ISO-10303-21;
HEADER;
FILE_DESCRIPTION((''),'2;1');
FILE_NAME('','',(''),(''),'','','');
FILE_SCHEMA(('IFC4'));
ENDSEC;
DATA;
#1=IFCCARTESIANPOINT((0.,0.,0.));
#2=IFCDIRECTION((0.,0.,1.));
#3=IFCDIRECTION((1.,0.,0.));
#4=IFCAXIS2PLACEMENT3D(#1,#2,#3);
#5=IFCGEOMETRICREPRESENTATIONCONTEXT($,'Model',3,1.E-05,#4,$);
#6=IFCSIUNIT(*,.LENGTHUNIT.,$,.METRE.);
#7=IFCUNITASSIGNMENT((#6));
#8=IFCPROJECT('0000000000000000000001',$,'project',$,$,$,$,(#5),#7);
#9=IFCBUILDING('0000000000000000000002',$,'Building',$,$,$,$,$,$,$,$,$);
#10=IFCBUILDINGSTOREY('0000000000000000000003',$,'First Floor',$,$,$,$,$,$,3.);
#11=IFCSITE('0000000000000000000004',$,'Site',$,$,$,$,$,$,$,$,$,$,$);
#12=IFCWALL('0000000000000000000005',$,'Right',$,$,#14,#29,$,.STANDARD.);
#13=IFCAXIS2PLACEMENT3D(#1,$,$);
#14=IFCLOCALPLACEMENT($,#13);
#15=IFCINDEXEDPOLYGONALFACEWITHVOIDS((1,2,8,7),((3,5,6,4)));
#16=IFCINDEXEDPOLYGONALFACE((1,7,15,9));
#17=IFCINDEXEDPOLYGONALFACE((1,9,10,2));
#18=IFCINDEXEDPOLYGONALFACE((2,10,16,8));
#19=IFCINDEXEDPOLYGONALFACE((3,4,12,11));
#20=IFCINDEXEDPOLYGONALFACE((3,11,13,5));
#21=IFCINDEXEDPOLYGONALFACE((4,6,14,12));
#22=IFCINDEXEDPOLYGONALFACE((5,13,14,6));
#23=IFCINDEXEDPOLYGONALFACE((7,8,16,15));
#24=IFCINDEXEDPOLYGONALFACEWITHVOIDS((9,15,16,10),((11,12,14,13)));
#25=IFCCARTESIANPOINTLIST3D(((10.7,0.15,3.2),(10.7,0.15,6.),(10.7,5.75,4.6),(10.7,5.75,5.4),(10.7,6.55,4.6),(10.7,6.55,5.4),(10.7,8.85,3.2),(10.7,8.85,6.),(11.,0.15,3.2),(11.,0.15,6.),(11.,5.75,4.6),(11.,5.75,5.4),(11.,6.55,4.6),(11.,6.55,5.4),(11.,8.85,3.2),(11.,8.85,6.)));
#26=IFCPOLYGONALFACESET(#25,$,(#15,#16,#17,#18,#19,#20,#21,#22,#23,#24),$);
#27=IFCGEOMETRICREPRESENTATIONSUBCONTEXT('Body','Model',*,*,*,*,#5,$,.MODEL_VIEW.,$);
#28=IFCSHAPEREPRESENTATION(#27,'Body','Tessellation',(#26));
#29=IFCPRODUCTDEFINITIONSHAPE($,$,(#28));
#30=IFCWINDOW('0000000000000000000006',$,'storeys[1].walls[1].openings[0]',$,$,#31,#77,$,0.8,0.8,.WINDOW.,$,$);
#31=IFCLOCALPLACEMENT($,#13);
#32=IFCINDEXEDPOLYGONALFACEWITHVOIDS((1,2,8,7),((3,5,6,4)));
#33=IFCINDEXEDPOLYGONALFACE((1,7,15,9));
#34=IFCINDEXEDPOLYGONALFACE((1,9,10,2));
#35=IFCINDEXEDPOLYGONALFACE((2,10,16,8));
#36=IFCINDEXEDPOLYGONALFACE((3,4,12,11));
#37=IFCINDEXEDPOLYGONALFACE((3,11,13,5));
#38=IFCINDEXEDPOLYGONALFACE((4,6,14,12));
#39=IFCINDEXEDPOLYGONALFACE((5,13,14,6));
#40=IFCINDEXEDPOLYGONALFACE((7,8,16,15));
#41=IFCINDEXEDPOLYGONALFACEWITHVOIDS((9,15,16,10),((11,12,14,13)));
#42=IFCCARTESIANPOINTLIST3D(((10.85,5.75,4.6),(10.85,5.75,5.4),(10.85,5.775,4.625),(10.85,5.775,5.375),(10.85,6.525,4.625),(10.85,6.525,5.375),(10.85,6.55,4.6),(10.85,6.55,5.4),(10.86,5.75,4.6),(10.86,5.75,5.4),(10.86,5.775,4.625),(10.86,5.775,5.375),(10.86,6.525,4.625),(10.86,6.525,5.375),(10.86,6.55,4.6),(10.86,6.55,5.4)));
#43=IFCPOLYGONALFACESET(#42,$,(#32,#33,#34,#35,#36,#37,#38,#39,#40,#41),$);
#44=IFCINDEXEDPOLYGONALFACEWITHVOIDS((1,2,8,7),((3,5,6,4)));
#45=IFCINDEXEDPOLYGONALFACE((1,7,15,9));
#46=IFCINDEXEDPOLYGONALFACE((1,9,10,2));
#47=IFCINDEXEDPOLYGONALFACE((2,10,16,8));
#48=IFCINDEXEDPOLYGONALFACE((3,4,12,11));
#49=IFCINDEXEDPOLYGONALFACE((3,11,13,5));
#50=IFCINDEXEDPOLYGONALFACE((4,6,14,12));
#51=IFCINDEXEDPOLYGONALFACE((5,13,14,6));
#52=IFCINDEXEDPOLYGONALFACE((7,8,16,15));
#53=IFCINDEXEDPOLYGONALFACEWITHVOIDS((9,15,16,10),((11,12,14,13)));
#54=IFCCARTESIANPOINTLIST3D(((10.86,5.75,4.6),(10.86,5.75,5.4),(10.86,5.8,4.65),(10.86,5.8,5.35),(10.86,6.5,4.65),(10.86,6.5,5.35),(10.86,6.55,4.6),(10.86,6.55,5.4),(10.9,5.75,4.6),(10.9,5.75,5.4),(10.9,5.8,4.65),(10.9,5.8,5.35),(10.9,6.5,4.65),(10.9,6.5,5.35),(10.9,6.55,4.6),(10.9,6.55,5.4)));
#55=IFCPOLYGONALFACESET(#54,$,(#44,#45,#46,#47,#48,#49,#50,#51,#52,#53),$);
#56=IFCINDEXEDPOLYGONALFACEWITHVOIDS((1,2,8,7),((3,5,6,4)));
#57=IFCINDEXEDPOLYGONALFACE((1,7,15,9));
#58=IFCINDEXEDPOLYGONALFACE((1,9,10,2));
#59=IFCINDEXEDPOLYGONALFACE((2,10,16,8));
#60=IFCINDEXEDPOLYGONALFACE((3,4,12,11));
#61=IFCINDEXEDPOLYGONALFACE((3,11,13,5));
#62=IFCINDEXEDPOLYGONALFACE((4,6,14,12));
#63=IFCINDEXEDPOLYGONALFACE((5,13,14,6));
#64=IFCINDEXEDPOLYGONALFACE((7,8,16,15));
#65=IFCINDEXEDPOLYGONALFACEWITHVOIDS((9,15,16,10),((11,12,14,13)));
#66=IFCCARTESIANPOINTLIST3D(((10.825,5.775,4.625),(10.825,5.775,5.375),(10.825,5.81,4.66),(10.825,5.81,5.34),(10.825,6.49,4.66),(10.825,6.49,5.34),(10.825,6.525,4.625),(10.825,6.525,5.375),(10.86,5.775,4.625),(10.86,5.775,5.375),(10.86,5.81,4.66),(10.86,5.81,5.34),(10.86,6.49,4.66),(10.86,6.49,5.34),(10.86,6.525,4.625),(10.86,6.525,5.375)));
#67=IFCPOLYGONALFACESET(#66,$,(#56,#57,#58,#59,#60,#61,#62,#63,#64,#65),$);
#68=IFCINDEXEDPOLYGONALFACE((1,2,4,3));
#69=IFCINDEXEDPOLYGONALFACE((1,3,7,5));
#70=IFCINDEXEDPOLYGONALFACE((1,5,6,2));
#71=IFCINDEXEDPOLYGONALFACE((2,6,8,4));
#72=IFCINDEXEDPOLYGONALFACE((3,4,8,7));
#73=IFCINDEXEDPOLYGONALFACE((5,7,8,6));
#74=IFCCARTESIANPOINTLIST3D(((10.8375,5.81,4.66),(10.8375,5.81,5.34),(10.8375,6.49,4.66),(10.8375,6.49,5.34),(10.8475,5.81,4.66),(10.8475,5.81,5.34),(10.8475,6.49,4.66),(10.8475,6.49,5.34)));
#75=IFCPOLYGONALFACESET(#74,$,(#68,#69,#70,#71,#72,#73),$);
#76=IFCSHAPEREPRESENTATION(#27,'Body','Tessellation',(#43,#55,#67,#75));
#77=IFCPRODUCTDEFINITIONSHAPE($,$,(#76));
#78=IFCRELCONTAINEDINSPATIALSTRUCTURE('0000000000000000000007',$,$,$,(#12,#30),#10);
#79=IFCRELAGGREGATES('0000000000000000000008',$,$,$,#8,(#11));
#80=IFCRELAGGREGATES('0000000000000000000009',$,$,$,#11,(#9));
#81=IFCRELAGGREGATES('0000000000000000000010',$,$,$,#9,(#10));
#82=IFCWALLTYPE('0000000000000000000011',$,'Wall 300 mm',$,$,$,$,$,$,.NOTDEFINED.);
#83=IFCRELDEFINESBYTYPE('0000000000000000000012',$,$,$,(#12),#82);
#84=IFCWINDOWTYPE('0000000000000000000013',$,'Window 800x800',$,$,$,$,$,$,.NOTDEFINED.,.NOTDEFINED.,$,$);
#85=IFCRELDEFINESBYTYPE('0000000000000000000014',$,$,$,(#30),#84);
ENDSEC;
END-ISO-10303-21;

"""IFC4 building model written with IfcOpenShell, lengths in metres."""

from ifc_helpers import new_model, si_unit, frame, origin_with_axes, place, context, subcontext, project, spatial, line, indexed_curve, outline, extrude, type_object, element, fill, save


model = new_model("IFC4")

# Units and contexts
model_context = context("Model", 3, precision=1e-05, world=origin_with_axes())
body_context = subcontext(model_context, "Body", "Model", "MODEL_VIEW")
ifc_project = project(units=[si_unit("LENGTHUNIT", "METRE")], contexts=[model_context])

# Site, building, storey
site = spatial("IfcSite", under=ifc_project, Name="Site")
building = spatial("IfcBuilding", under=site, Name="Building")
storey = spatial("IfcBuildingStorey", under=building, Name="First Floor", Elevation=3.0)

# Shared definitions
wall_type_1 = type_object("IfcWallType", Name="Wall 300 mm", PredefinedType="NOTDEFINED")

# Wall, opening, window
wall_1_placement = place(None, frame((10.85, 0.15, 3.2), z_axis=(0.0, 0.0, 1.0), x_axis=(0.0, 1.0, 0.0)))
wall_1 = element("IfcWall", 1, at=wall_1_placement, inside=storey, type_object=wall_type_1, Name="Right", PredefinedType="STANDARD", context=body_context, shape_type="SweptSolid", body=[
    extrude(outline(indexed_curve([(0.0, 0.0), (0.0, 0.3), (8.7, 0.3), (8.7, 0.0), (0.0, 0.0)], self_intersect=False)), frame((0.0, -0.15, 0.0), z_axis=(0.0, 0.0, 1.0), x_axis=(1.0, 0.0, 0.0)), (0.0, 0.0, 1.0), 2.8),
])
opening_1_placement = place(wall_1_placement, frame((5.6, -0.16, 1.4), z_axis=(0.0, 0.0, 1.0), x_axis=(1.0, 0.0, 0.0)))
opening_1 = element("IfcOpeningElement", 2, at=opening_1_placement, cuts=wall_1, context=body_context, shape_type="SweptSolid", body=[
    extrude(outline(indexed_curve([(0.0, 0.0), (0.0, 0.32), (0.8, 0.32), (0.8, 0.0), (0.0, 0.0)], self_intersect=False)), origin_with_axes(), (0.0, 0.0, 1.0), 0.8),
])
window_type_1 = type_object("IfcWindowType", Name="Window 800x800", PartitioningType="NOTDEFINED", PredefinedType="NOTDEFINED")
window_1_placement = place(None, frame((10.95, 5.75, 4.6), z_axis=(0.0, 0.0, 1.0), x_axis=(0.0, 1.0, 0.0)))
window_1 = element("IfcWindow", 3, at=window_1_placement, inside=storey, type_object=window_type_1, Name="storeys[1].walls[1].openings[0]", OverallHeight=0.8, OverallWidth=0.8, PredefinedType="WINDOW", context=body_context, shape_type="SweptSolid", body=[
    extrude(outline(indexed_curve([(0.0, 0.0), (0.8, 0.0), (0.8, 0.8), (0.0, 0.8)], segments=[line(1, 2, 3, 4, 1)]), holes=[indexed_curve([(0.025, 0.025), (0.775, 0.025), (0.775, 0.775), (0.025, 0.775)], segments=[line(1, 2, 3, 4, 1)])]), frame((0.0, 0.09, 0.0), z_axis=(0.0, -1.0, 0.0), x_axis=(1.0, 0.0, 0.0)), (0.0, 0.0, -1.0), 0.01),
    extrude(outline(indexed_curve([(0.0, 0.0), (0.8, 0.0), (0.8, 0.8), (0.0, 0.8)], segments=[line(1, 2, 3, 4, 1)]), holes=[indexed_curve([(0.05, 0.05), (0.75, 0.05), (0.75, 0.75), (0.05, 0.75)], segments=[line(1, 2, 3, 4, 1)])]), frame((0.0, 0.05, 0.0), z_axis=(0.0, -1.0, 0.0), x_axis=(1.0, 0.0, 0.0)), (0.0, 0.0, -1.0), 0.04),
    extrude(outline(indexed_curve([(0.0, 0.0), (0.75, 0.0), (0.75, 0.75), (0.0, 0.75)], segments=[line(1, 2, 3, 4, 1)]), holes=[indexed_curve([(0.035, 0.035), (0.715, 0.035), (0.715, 0.715), (0.035, 0.715)], segments=[line(1, 2, 3, 4, 1)])]), frame((0.025, 0.09, 0.025), z_axis=(0.0, -1.0, 0.0), x_axis=(1.0, 0.0, 0.0)), (0.0, 0.0, -1.0), 0.035),
    extrude(outline(indexed_curve([(0.035, 0.035), (0.715, 0.035), (0.715, 0.715), (0.035, 0.715)], segments=[line(1, 2, 3, 4, 1)])), frame((0.025, 0.1025, 0.025), z_axis=(0.0, -1.0, 0.0), x_axis=(1.0, 0.0, 0.0)), (0.0, 0.0, -1.0), 0.01),
])
fill(opening_1, window_1)

save(model, "model.ifc")
